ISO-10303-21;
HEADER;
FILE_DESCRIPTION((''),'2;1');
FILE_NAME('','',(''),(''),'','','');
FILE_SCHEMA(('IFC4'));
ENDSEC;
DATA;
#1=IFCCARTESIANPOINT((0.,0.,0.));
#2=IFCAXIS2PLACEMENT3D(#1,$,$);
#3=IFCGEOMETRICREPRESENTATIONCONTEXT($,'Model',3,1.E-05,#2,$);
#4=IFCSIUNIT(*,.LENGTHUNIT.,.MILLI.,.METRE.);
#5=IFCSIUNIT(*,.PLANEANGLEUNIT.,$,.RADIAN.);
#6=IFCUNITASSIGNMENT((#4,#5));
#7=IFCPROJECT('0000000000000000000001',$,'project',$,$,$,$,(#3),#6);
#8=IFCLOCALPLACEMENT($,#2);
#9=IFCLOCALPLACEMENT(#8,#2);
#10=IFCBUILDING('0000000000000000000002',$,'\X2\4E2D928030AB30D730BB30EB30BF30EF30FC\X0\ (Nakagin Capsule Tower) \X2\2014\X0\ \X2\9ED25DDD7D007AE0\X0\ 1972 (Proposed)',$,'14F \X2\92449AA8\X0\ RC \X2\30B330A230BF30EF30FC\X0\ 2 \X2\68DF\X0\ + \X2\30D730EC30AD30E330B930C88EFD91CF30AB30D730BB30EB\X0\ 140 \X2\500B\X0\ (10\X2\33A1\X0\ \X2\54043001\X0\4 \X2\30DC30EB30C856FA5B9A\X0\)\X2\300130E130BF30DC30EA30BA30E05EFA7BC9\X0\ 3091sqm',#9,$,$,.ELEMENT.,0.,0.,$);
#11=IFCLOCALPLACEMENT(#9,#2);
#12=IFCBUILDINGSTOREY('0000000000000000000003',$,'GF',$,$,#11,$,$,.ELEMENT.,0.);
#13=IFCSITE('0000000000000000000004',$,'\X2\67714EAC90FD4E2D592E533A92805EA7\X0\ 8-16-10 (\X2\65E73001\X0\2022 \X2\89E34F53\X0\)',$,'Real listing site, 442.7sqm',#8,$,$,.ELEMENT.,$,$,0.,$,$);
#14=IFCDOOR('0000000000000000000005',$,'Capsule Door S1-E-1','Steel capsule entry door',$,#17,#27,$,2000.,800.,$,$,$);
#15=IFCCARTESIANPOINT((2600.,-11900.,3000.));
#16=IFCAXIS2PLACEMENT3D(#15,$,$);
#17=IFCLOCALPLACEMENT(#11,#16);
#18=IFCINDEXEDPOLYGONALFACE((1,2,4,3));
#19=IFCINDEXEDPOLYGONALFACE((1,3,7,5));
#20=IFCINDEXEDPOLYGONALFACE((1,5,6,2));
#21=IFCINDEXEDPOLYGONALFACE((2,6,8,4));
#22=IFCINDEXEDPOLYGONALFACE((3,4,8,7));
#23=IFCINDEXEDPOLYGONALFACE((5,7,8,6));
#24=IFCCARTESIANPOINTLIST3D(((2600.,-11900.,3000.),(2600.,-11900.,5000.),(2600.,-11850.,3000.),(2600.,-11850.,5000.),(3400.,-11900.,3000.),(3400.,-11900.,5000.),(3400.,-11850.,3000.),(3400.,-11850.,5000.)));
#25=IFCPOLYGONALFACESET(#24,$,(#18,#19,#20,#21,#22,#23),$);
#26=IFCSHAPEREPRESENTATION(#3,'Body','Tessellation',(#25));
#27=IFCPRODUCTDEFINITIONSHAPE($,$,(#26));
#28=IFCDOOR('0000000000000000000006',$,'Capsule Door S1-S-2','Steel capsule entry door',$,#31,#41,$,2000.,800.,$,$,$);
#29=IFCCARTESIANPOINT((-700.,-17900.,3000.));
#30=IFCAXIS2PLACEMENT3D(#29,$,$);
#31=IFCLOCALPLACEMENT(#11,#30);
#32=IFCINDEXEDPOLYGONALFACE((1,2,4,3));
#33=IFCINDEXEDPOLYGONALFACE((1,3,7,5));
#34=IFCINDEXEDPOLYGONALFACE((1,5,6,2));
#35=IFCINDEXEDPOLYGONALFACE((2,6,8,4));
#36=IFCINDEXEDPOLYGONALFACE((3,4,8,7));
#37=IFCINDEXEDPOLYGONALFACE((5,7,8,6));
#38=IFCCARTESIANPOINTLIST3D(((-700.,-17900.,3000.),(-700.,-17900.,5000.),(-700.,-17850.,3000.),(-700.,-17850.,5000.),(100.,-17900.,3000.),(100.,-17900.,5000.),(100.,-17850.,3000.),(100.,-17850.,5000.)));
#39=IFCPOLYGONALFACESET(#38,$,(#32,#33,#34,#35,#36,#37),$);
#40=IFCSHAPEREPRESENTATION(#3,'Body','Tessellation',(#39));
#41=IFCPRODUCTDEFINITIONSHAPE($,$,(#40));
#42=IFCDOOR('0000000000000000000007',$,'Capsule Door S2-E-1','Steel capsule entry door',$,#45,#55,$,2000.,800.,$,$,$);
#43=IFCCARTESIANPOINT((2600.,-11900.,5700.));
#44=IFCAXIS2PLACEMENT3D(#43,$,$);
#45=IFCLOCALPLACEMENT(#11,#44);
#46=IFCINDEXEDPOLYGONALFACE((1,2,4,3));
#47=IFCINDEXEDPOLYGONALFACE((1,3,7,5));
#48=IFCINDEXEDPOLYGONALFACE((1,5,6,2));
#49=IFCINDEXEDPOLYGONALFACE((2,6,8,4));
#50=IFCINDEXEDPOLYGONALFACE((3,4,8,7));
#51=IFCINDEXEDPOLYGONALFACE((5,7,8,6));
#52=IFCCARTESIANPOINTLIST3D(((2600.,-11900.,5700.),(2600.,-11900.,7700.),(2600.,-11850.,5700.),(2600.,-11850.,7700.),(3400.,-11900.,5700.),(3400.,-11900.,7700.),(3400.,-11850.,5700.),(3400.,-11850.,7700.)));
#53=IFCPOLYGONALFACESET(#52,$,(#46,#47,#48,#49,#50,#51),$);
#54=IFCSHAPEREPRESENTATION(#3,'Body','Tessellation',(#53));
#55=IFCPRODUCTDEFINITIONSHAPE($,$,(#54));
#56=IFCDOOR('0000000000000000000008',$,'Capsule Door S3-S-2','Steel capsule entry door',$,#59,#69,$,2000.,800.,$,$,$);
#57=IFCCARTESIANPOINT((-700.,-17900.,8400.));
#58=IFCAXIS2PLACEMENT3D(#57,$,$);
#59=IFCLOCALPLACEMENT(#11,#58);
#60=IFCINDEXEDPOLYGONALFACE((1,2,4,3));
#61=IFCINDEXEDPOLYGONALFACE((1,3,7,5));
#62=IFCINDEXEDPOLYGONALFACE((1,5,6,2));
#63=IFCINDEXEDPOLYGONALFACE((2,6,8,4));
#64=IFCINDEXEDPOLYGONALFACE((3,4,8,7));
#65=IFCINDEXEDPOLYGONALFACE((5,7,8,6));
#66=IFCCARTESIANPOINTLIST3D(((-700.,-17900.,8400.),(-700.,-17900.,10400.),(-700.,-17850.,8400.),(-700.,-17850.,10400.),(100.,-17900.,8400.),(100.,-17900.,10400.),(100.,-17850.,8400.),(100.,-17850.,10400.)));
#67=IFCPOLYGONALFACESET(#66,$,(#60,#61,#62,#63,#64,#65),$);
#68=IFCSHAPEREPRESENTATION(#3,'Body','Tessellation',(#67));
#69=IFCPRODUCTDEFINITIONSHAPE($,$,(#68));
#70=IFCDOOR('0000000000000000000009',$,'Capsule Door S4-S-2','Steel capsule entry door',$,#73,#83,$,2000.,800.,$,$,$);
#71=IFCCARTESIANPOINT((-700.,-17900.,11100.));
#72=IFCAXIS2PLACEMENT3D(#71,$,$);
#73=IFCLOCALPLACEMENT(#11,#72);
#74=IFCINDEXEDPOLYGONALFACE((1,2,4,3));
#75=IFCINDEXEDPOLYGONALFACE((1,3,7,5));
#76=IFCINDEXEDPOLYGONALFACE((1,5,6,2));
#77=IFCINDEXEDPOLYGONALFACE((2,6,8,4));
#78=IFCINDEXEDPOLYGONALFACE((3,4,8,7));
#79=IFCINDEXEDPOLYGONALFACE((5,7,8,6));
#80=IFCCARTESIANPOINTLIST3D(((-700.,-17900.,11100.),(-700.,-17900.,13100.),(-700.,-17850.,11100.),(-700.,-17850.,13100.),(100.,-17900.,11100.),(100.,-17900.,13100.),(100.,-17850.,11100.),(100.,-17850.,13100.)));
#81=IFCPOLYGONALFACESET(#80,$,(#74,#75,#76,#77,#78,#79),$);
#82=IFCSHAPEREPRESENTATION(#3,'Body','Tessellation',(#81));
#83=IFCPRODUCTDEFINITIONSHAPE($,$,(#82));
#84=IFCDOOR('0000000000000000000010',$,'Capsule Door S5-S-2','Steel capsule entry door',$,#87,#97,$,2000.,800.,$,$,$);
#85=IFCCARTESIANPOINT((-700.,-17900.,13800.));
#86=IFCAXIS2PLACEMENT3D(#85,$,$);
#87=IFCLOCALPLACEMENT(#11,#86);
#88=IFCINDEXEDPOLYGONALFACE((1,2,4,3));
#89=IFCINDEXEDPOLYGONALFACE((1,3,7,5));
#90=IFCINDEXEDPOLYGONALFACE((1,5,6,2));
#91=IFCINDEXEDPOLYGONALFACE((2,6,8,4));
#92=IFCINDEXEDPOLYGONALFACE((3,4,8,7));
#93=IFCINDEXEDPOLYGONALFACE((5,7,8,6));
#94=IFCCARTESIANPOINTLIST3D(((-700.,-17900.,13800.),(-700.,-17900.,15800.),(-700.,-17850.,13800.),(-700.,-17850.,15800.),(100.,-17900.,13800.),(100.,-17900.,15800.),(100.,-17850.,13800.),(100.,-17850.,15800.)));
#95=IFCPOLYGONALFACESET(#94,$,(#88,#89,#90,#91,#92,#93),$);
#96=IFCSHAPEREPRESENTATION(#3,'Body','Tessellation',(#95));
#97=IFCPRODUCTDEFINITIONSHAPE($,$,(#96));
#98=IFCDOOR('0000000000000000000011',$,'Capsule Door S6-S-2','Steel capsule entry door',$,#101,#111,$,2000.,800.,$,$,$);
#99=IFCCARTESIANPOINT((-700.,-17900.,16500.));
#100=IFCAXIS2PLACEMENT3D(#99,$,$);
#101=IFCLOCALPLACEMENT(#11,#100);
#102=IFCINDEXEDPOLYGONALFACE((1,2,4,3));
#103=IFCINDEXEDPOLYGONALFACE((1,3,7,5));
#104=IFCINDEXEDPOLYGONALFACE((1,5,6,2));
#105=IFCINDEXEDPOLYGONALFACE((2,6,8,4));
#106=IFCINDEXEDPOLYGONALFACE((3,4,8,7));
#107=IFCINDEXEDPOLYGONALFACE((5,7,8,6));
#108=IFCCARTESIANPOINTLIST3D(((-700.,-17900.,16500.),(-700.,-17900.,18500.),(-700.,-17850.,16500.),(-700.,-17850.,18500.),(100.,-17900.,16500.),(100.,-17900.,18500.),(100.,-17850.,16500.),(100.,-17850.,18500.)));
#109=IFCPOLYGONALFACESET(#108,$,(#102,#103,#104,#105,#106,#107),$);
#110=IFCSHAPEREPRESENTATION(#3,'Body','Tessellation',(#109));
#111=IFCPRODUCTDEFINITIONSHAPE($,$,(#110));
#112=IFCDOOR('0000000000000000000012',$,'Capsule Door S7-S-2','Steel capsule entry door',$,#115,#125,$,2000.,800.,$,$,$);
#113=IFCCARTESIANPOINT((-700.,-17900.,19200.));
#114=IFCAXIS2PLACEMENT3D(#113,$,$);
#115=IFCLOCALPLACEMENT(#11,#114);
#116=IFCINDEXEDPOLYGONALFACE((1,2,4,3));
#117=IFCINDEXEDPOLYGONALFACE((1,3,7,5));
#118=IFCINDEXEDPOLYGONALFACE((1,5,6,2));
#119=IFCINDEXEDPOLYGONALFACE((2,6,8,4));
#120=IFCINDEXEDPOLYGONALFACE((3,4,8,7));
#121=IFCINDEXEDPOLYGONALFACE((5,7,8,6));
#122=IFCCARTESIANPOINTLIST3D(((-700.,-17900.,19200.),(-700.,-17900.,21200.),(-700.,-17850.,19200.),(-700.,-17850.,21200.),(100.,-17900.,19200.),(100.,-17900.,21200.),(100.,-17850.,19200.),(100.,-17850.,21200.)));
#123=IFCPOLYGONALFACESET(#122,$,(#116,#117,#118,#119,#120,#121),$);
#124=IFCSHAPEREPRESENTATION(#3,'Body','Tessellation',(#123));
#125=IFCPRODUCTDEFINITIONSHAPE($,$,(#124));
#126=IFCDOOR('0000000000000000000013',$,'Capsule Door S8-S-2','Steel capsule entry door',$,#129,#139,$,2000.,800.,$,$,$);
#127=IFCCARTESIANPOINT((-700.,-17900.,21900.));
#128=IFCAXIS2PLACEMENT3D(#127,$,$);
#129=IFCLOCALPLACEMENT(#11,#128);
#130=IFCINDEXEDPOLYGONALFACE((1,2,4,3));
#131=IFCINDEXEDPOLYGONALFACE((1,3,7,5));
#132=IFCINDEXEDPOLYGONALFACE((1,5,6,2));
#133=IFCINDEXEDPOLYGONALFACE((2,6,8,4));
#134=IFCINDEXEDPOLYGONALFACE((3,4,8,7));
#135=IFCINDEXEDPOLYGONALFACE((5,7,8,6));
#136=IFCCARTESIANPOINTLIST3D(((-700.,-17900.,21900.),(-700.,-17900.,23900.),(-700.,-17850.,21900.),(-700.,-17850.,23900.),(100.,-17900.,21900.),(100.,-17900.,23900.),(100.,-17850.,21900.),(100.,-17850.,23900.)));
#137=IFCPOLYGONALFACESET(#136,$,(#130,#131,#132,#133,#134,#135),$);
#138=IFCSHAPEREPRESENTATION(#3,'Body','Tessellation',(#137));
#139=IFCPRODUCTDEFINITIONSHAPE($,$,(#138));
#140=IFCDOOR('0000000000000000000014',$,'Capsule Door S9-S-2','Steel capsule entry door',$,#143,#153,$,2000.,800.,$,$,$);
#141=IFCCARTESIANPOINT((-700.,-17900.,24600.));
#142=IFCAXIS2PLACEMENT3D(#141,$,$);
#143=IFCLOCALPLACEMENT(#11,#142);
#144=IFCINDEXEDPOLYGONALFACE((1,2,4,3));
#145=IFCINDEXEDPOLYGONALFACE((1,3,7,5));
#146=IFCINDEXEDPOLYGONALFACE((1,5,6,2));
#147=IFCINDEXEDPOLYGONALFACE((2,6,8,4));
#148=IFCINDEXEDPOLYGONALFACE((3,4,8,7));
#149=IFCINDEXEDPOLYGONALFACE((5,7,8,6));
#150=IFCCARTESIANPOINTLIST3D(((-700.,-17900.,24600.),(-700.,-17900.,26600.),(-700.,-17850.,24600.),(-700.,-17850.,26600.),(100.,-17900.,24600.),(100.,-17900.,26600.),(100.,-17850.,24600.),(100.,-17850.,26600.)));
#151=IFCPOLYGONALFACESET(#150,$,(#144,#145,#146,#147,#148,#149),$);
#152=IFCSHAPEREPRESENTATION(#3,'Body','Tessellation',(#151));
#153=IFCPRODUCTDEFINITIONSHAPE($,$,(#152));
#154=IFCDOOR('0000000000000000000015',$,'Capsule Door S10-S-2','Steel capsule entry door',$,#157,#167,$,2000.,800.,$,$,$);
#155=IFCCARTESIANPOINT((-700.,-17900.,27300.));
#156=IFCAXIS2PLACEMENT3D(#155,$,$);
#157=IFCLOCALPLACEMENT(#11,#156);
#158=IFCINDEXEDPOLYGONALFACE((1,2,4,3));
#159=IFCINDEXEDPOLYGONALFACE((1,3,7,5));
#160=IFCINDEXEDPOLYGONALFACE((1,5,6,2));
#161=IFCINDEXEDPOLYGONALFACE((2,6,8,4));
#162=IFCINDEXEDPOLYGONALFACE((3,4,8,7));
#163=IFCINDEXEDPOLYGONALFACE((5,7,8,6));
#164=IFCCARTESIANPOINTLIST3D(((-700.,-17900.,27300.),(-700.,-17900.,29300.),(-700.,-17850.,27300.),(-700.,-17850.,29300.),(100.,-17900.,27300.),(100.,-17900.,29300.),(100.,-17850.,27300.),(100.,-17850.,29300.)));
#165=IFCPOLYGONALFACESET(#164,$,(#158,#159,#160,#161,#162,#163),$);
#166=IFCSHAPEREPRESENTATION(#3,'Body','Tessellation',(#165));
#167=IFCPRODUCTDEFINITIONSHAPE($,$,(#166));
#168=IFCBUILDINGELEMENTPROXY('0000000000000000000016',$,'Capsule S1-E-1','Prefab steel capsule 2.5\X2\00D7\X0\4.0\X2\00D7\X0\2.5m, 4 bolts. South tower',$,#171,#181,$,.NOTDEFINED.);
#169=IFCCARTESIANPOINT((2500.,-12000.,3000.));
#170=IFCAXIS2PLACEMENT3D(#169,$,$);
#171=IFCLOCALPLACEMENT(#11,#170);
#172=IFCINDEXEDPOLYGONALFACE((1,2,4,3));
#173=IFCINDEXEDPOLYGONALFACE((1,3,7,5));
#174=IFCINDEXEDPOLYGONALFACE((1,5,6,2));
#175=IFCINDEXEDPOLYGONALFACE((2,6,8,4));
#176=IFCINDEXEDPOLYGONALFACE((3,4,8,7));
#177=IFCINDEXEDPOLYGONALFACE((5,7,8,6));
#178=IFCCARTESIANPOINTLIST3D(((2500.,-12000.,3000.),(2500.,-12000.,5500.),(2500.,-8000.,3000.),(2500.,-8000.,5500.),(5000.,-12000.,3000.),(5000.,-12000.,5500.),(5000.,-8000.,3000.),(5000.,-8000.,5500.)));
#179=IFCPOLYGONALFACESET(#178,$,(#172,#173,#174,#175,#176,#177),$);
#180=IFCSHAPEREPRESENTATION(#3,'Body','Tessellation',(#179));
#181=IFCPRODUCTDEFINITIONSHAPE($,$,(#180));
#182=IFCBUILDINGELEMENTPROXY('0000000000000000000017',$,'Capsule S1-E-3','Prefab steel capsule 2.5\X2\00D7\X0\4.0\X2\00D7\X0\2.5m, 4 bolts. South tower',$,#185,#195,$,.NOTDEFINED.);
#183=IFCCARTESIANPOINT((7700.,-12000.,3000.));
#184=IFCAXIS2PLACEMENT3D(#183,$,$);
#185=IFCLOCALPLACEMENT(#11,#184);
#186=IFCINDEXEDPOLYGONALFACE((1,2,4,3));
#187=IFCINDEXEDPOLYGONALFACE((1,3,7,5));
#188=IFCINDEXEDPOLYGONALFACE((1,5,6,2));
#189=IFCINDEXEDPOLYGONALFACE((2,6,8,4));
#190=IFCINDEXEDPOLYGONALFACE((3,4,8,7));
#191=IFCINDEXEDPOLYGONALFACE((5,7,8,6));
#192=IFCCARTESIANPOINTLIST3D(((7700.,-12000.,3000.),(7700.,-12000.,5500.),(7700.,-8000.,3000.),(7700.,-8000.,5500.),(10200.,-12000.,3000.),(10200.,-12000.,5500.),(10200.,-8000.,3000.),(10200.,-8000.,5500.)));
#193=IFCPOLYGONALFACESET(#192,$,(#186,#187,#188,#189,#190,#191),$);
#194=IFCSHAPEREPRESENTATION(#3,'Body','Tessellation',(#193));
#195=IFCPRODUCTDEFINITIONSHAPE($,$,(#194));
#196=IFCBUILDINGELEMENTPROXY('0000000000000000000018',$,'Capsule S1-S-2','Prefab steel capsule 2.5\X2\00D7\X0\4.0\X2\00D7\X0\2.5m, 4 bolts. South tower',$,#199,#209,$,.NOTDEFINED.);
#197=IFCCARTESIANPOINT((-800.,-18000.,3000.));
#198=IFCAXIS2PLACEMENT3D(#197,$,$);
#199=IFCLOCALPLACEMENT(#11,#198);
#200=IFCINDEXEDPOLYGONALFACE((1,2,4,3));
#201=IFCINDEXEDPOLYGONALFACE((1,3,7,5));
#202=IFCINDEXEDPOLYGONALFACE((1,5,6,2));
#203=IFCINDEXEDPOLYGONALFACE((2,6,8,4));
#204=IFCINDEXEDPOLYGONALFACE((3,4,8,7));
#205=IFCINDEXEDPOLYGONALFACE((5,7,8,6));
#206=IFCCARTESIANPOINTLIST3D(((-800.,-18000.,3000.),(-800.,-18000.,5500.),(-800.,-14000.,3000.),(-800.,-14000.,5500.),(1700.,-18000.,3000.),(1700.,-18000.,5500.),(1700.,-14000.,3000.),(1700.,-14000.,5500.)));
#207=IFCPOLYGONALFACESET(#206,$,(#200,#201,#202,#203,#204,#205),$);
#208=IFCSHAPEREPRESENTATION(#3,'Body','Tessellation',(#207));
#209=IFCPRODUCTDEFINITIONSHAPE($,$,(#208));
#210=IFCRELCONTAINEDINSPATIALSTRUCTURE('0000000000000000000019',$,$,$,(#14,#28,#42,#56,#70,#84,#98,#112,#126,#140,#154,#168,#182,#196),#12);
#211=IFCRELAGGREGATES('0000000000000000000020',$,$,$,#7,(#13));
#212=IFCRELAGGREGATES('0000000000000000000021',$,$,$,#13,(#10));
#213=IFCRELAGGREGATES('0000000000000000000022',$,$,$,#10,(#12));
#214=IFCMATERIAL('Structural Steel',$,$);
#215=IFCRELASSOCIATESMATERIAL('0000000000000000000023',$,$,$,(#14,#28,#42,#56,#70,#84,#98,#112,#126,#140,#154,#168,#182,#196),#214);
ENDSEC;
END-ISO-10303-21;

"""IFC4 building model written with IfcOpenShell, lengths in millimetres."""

from ifc_helpers import new_model, si_unit, frame, frame_2d, origin, place, context, project, spatial, rectangle, extrude, material, element, save


model = new_model("IFC4")

# Units and contexts
model_context = context("Model", 3, precision=1e-05, world=origin())
ifc_project = project(units=[si_unit("LENGTHUNIT", "METRE", prefix="MILLI"), si_unit("PLANEANGLEUNIT", "RADIAN")], contexts=[model_context])

# Site, building, storey
site_placement = place(None, origin())
site = spatial("IfcSite", under=ifc_project, at=site_placement, Name="東京都中央区銀座 8-16-10 (旧、2022 解体)", ObjectType="Real listing site, 442.7sqm", CompositionType="ELEMENT", RefElevation=0.0)
building_placement = place(site_placement, origin())
building = spatial("IfcBuilding", under=site, at=building_placement, Name="中銀カプセルタワー (Nakagin Capsule Tower) — 黒川紀章 1972 (Proposed)", ObjectType="14F 鉄骨 RC コアタワー 2 棟 + プレキャスト軽量カプセル 140 個 (10㎡ 各、4 ボルト固定)、メタボリズム建築 3091sqm", CompositionType="ELEMENT", ElevationOfRefHeight=0.0, ElevationOfTerrain=0.0)
storey_placement = place(building_placement, origin())
storey = spatial("IfcBuildingStorey", under=building, at=storey_placement, Name="GF", CompositionType="ELEMENT", Elevation=0.0)

# Doors
ifc_material_1 = material(Name="Structural Steel")
door_1_placement = place(storey_placement, frame((2600.0, -11900.0, 3000.0)))
element("IfcDoor", 1, at=door_1_placement, inside=storey, material=ifc_material_1, Name="Capsule Door S1-E-1", Description="Steel capsule entry door", OverallHeight=2000.0, OverallWidth=800.0, context=model_context, shape_type="SweptSolid", body=[
    extrude(rectangle(XDim=800.0, YDim=50.0, at=frame_2d((400.0, 25.0))), frame((2600.0, -11900.0, 3000.0)), (0.0, 0.0, 1.0), 2000.0),
])
door_2_placement = place(storey_placement, frame((-700.0, -17900.0, 3000.0)))
element("IfcDoor", 2, at=door_2_placement, inside=storey, material=ifc_material_1, Name="Capsule Door S1-S-2", Description="Steel capsule entry door", OverallHeight=2000.0, OverallWidth=800.0, context=model_context, shape_type="SweptSolid", body=[
    extrude(rectangle(XDim=800.0, YDim=50.0, at=frame_2d((400.0, 25.0))), frame((-700.0, -17900.0, 3000.0)), (0.0, 0.0, 1.0), 2000.0),
])
door_3_placement = place(storey_placement, frame((2600.0, -11900.0, 5700.0)))
element("IfcDoor", 3, at=door_3_placement, inside=storey, material=ifc_material_1, Name="Capsule Door S2-E-1", Description="Steel capsule entry door", OverallHeight=2000.0, OverallWidth=800.0, context=model_context, shape_type="SweptSolid", body=[
    extrude(rectangle(XDim=800.0, YDim=50.0, at=frame_2d((400.0, 25.0))), frame((2600.0, -11900.0, 5700.0)), (0.0, 0.0, 1.0), 2000.0),
])
door_4_placement = place(storey_placement, frame((-700.0, -17900.0, 8400.0)))
element("IfcDoor", 4, at=door_4_placement, inside=storey, material=ifc_material_1, Name="Capsule Door S3-S-2", Description="Steel capsule entry door", OverallHeight=2000.0, OverallWidth=800.0, context=model_context, shape_type="SweptSolid", body=[
    extrude(rectangle(XDim=800.0, YDim=50.0, at=frame_2d((400.0, 25.0))), frame((-700.0, -17900.0, 8400.0)), (0.0, 0.0, 1.0), 2000.0),
])
door_5_placement = place(storey_placement, frame((-700.0, -17900.0, 11100.0)))
element("IfcDoor", 5, at=door_5_placement, inside=storey, material=ifc_material_1, Name="Capsule Door S4-S-2", Description="Steel capsule entry door", OverallHeight=2000.0, OverallWidth=800.0, context=model_context, shape_type="SweptSolid", body=[
    extrude(rectangle(XDim=800.0, YDim=50.0, at=frame_2d((400.0, 25.0))), frame((-700.0, -17900.0, 11100.0)), (0.0, 0.0, 1.0), 2000.0),
])
door_6_placement = place(storey_placement, frame((-700.0, -17900.0, 13800.0)))
element("IfcDoor", 6, at=door_6_placement, inside=storey, material=ifc_material_1, Name="Capsule Door S5-S-2", Description="Steel capsule entry door", OverallHeight=2000.0, OverallWidth=800.0, context=model_context, shape_type="SweptSolid", body=[
    extrude(rectangle(XDim=800.0, YDim=50.0, at=frame_2d((400.0, 25.0))), frame((-700.0, -17900.0, 13800.0)), (0.0, 0.0, 1.0), 2000.0),
])
door_7_placement = place(storey_placement, frame((-700.0, -17900.0, 16500.0)))
element("IfcDoor", 7, at=door_7_placement, inside=storey, material=ifc_material_1, Name="Capsule Door S6-S-2", Description="Steel capsule entry door", OverallHeight=2000.0, OverallWidth=800.0, context=model_context, shape_type="SweptSolid", body=[
    extrude(rectangle(XDim=800.0, YDim=50.0, at=frame_2d((400.0, 25.0))), frame((-700.0, -17900.0, 16500.0)), (0.0, 0.0, 1.0), 2000.0),
])
door_8_placement = place(storey_placement, frame((-700.0, -17900.0, 19200.0)))
element("IfcDoor", 8, at=door_8_placement, inside=storey, material=ifc_material_1, Name="Capsule Door S7-S-2", Description="Steel capsule entry door", OverallHeight=2000.0, OverallWidth=800.0, context=model_context, shape_type="SweptSolid", body=[
    extrude(rectangle(XDim=800.0, YDim=50.0, at=frame_2d((400.0, 25.0))), frame((-700.0, -17900.0, 19200.0)), (0.0, 0.0, 1.0), 2000.0),
])
door_9_placement = place(storey_placement, frame((-700.0, -17900.0, 21900.0)))
element("IfcDoor", 9, at=door_9_placement, inside=storey, material=ifc_material_1, Name="Capsule Door S8-S-2", Description="Steel capsule entry door", OverallHeight=2000.0, OverallWidth=800.0, context=model_context, shape_type="SweptSolid", body=[
    extrude(rectangle(XDim=800.0, YDim=50.0, at=frame_2d((400.0, 25.0))), frame((-700.0, -17900.0, 21900.0)), (0.0, 0.0, 1.0), 2000.0),
])
door_10_placement = place(storey_placement, frame((-700.0, -17900.0, 24600.0)))
element("IfcDoor", 10, at=door_10_placement, inside=storey, material=ifc_material_1, Name="Capsule Door S9-S-2", Description="Steel capsule entry door", OverallHeight=2000.0, OverallWidth=800.0, context=model_context, shape_type="SweptSolid", body=[
    extrude(rectangle(XDim=800.0, YDim=50.0, at=frame_2d((400.0, 25.0))), frame((-700.0, -17900.0, 24600.0)), (0.0, 0.0, 1.0), 2000.0),
])
door_11_placement = place(storey_placement, frame((-700.0, -17900.0, 27300.0)))
element("IfcDoor", 11, at=door_11_placement, inside=storey, material=ifc_material_1, Name="Capsule Door S10-S-2", Description="Steel capsule entry door", OverallHeight=2000.0, OverallWidth=800.0, context=model_context, shape_type="SweptSolid", body=[
    extrude(rectangle(XDim=800.0, YDim=50.0, at=frame_2d((400.0, 25.0))), frame((-700.0, -17900.0, 27300.0)), (0.0, 0.0, 1.0), 2000.0),
])

# Building element proxies
proxy_1_placement = place(storey_placement, frame((2500.0, -12000.0, 3000.0)))
element("IfcBuildingElementProxy", 12, at=proxy_1_placement, inside=storey, material=ifc_material_1, Name="Capsule S1-E-1", Description="Prefab steel capsule 2.5×4.0×2.5m, 4 bolts. South tower", PredefinedType="NOTDEFINED", context=model_context, shape_type="SweptSolid", body=[
    extrude(rectangle(XDim=2500.0, YDim=4000.0, at=frame_2d((1250.0, 2000.0))), frame((2500.0, -12000.0, 3000.0)), (0.0, 0.0, 1.0), 2500.0),
])
proxy_2_placement = place(storey_placement, frame((7700.0, -12000.0, 3000.0)))
element("IfcBuildingElementProxy", 13, at=proxy_2_placement, inside=storey, material=ifc_material_1, Name="Capsule S1-E-3", Description="Prefab steel capsule 2.5×4.0×2.5m, 4 bolts. South tower", PredefinedType="NOTDEFINED", context=model_context, shape_type="SweptSolid", body=[
    extrude(rectangle(XDim=2500.0, YDim=4000.0, at=frame_2d((1250.0, 2000.0))), frame((7700.0, -12000.0, 3000.0)), (0.0, 0.0, 1.0), 2500.0),
])
proxy_3_placement = place(storey_placement, frame((-800.0, -18000.0, 3000.0)))
element("IfcBuildingElementProxy", 14, at=proxy_3_placement, inside=storey, material=ifc_material_1, Name="Capsule S1-S-2", Description="Prefab steel capsule 2.5×4.0×2.5m, 4 bolts. South tower", PredefinedType="NOTDEFINED", context=model_context, shape_type="SweptSolid", body=[
    extrude(rectangle(XDim=2500.0, YDim=4000.0, at=frame_2d((1250.0, 2000.0))), frame((-800.0, -18000.0, 3000.0)), (0.0, 0.0, 1.0), 2500.0),
])

save(model, "model.ifc")
